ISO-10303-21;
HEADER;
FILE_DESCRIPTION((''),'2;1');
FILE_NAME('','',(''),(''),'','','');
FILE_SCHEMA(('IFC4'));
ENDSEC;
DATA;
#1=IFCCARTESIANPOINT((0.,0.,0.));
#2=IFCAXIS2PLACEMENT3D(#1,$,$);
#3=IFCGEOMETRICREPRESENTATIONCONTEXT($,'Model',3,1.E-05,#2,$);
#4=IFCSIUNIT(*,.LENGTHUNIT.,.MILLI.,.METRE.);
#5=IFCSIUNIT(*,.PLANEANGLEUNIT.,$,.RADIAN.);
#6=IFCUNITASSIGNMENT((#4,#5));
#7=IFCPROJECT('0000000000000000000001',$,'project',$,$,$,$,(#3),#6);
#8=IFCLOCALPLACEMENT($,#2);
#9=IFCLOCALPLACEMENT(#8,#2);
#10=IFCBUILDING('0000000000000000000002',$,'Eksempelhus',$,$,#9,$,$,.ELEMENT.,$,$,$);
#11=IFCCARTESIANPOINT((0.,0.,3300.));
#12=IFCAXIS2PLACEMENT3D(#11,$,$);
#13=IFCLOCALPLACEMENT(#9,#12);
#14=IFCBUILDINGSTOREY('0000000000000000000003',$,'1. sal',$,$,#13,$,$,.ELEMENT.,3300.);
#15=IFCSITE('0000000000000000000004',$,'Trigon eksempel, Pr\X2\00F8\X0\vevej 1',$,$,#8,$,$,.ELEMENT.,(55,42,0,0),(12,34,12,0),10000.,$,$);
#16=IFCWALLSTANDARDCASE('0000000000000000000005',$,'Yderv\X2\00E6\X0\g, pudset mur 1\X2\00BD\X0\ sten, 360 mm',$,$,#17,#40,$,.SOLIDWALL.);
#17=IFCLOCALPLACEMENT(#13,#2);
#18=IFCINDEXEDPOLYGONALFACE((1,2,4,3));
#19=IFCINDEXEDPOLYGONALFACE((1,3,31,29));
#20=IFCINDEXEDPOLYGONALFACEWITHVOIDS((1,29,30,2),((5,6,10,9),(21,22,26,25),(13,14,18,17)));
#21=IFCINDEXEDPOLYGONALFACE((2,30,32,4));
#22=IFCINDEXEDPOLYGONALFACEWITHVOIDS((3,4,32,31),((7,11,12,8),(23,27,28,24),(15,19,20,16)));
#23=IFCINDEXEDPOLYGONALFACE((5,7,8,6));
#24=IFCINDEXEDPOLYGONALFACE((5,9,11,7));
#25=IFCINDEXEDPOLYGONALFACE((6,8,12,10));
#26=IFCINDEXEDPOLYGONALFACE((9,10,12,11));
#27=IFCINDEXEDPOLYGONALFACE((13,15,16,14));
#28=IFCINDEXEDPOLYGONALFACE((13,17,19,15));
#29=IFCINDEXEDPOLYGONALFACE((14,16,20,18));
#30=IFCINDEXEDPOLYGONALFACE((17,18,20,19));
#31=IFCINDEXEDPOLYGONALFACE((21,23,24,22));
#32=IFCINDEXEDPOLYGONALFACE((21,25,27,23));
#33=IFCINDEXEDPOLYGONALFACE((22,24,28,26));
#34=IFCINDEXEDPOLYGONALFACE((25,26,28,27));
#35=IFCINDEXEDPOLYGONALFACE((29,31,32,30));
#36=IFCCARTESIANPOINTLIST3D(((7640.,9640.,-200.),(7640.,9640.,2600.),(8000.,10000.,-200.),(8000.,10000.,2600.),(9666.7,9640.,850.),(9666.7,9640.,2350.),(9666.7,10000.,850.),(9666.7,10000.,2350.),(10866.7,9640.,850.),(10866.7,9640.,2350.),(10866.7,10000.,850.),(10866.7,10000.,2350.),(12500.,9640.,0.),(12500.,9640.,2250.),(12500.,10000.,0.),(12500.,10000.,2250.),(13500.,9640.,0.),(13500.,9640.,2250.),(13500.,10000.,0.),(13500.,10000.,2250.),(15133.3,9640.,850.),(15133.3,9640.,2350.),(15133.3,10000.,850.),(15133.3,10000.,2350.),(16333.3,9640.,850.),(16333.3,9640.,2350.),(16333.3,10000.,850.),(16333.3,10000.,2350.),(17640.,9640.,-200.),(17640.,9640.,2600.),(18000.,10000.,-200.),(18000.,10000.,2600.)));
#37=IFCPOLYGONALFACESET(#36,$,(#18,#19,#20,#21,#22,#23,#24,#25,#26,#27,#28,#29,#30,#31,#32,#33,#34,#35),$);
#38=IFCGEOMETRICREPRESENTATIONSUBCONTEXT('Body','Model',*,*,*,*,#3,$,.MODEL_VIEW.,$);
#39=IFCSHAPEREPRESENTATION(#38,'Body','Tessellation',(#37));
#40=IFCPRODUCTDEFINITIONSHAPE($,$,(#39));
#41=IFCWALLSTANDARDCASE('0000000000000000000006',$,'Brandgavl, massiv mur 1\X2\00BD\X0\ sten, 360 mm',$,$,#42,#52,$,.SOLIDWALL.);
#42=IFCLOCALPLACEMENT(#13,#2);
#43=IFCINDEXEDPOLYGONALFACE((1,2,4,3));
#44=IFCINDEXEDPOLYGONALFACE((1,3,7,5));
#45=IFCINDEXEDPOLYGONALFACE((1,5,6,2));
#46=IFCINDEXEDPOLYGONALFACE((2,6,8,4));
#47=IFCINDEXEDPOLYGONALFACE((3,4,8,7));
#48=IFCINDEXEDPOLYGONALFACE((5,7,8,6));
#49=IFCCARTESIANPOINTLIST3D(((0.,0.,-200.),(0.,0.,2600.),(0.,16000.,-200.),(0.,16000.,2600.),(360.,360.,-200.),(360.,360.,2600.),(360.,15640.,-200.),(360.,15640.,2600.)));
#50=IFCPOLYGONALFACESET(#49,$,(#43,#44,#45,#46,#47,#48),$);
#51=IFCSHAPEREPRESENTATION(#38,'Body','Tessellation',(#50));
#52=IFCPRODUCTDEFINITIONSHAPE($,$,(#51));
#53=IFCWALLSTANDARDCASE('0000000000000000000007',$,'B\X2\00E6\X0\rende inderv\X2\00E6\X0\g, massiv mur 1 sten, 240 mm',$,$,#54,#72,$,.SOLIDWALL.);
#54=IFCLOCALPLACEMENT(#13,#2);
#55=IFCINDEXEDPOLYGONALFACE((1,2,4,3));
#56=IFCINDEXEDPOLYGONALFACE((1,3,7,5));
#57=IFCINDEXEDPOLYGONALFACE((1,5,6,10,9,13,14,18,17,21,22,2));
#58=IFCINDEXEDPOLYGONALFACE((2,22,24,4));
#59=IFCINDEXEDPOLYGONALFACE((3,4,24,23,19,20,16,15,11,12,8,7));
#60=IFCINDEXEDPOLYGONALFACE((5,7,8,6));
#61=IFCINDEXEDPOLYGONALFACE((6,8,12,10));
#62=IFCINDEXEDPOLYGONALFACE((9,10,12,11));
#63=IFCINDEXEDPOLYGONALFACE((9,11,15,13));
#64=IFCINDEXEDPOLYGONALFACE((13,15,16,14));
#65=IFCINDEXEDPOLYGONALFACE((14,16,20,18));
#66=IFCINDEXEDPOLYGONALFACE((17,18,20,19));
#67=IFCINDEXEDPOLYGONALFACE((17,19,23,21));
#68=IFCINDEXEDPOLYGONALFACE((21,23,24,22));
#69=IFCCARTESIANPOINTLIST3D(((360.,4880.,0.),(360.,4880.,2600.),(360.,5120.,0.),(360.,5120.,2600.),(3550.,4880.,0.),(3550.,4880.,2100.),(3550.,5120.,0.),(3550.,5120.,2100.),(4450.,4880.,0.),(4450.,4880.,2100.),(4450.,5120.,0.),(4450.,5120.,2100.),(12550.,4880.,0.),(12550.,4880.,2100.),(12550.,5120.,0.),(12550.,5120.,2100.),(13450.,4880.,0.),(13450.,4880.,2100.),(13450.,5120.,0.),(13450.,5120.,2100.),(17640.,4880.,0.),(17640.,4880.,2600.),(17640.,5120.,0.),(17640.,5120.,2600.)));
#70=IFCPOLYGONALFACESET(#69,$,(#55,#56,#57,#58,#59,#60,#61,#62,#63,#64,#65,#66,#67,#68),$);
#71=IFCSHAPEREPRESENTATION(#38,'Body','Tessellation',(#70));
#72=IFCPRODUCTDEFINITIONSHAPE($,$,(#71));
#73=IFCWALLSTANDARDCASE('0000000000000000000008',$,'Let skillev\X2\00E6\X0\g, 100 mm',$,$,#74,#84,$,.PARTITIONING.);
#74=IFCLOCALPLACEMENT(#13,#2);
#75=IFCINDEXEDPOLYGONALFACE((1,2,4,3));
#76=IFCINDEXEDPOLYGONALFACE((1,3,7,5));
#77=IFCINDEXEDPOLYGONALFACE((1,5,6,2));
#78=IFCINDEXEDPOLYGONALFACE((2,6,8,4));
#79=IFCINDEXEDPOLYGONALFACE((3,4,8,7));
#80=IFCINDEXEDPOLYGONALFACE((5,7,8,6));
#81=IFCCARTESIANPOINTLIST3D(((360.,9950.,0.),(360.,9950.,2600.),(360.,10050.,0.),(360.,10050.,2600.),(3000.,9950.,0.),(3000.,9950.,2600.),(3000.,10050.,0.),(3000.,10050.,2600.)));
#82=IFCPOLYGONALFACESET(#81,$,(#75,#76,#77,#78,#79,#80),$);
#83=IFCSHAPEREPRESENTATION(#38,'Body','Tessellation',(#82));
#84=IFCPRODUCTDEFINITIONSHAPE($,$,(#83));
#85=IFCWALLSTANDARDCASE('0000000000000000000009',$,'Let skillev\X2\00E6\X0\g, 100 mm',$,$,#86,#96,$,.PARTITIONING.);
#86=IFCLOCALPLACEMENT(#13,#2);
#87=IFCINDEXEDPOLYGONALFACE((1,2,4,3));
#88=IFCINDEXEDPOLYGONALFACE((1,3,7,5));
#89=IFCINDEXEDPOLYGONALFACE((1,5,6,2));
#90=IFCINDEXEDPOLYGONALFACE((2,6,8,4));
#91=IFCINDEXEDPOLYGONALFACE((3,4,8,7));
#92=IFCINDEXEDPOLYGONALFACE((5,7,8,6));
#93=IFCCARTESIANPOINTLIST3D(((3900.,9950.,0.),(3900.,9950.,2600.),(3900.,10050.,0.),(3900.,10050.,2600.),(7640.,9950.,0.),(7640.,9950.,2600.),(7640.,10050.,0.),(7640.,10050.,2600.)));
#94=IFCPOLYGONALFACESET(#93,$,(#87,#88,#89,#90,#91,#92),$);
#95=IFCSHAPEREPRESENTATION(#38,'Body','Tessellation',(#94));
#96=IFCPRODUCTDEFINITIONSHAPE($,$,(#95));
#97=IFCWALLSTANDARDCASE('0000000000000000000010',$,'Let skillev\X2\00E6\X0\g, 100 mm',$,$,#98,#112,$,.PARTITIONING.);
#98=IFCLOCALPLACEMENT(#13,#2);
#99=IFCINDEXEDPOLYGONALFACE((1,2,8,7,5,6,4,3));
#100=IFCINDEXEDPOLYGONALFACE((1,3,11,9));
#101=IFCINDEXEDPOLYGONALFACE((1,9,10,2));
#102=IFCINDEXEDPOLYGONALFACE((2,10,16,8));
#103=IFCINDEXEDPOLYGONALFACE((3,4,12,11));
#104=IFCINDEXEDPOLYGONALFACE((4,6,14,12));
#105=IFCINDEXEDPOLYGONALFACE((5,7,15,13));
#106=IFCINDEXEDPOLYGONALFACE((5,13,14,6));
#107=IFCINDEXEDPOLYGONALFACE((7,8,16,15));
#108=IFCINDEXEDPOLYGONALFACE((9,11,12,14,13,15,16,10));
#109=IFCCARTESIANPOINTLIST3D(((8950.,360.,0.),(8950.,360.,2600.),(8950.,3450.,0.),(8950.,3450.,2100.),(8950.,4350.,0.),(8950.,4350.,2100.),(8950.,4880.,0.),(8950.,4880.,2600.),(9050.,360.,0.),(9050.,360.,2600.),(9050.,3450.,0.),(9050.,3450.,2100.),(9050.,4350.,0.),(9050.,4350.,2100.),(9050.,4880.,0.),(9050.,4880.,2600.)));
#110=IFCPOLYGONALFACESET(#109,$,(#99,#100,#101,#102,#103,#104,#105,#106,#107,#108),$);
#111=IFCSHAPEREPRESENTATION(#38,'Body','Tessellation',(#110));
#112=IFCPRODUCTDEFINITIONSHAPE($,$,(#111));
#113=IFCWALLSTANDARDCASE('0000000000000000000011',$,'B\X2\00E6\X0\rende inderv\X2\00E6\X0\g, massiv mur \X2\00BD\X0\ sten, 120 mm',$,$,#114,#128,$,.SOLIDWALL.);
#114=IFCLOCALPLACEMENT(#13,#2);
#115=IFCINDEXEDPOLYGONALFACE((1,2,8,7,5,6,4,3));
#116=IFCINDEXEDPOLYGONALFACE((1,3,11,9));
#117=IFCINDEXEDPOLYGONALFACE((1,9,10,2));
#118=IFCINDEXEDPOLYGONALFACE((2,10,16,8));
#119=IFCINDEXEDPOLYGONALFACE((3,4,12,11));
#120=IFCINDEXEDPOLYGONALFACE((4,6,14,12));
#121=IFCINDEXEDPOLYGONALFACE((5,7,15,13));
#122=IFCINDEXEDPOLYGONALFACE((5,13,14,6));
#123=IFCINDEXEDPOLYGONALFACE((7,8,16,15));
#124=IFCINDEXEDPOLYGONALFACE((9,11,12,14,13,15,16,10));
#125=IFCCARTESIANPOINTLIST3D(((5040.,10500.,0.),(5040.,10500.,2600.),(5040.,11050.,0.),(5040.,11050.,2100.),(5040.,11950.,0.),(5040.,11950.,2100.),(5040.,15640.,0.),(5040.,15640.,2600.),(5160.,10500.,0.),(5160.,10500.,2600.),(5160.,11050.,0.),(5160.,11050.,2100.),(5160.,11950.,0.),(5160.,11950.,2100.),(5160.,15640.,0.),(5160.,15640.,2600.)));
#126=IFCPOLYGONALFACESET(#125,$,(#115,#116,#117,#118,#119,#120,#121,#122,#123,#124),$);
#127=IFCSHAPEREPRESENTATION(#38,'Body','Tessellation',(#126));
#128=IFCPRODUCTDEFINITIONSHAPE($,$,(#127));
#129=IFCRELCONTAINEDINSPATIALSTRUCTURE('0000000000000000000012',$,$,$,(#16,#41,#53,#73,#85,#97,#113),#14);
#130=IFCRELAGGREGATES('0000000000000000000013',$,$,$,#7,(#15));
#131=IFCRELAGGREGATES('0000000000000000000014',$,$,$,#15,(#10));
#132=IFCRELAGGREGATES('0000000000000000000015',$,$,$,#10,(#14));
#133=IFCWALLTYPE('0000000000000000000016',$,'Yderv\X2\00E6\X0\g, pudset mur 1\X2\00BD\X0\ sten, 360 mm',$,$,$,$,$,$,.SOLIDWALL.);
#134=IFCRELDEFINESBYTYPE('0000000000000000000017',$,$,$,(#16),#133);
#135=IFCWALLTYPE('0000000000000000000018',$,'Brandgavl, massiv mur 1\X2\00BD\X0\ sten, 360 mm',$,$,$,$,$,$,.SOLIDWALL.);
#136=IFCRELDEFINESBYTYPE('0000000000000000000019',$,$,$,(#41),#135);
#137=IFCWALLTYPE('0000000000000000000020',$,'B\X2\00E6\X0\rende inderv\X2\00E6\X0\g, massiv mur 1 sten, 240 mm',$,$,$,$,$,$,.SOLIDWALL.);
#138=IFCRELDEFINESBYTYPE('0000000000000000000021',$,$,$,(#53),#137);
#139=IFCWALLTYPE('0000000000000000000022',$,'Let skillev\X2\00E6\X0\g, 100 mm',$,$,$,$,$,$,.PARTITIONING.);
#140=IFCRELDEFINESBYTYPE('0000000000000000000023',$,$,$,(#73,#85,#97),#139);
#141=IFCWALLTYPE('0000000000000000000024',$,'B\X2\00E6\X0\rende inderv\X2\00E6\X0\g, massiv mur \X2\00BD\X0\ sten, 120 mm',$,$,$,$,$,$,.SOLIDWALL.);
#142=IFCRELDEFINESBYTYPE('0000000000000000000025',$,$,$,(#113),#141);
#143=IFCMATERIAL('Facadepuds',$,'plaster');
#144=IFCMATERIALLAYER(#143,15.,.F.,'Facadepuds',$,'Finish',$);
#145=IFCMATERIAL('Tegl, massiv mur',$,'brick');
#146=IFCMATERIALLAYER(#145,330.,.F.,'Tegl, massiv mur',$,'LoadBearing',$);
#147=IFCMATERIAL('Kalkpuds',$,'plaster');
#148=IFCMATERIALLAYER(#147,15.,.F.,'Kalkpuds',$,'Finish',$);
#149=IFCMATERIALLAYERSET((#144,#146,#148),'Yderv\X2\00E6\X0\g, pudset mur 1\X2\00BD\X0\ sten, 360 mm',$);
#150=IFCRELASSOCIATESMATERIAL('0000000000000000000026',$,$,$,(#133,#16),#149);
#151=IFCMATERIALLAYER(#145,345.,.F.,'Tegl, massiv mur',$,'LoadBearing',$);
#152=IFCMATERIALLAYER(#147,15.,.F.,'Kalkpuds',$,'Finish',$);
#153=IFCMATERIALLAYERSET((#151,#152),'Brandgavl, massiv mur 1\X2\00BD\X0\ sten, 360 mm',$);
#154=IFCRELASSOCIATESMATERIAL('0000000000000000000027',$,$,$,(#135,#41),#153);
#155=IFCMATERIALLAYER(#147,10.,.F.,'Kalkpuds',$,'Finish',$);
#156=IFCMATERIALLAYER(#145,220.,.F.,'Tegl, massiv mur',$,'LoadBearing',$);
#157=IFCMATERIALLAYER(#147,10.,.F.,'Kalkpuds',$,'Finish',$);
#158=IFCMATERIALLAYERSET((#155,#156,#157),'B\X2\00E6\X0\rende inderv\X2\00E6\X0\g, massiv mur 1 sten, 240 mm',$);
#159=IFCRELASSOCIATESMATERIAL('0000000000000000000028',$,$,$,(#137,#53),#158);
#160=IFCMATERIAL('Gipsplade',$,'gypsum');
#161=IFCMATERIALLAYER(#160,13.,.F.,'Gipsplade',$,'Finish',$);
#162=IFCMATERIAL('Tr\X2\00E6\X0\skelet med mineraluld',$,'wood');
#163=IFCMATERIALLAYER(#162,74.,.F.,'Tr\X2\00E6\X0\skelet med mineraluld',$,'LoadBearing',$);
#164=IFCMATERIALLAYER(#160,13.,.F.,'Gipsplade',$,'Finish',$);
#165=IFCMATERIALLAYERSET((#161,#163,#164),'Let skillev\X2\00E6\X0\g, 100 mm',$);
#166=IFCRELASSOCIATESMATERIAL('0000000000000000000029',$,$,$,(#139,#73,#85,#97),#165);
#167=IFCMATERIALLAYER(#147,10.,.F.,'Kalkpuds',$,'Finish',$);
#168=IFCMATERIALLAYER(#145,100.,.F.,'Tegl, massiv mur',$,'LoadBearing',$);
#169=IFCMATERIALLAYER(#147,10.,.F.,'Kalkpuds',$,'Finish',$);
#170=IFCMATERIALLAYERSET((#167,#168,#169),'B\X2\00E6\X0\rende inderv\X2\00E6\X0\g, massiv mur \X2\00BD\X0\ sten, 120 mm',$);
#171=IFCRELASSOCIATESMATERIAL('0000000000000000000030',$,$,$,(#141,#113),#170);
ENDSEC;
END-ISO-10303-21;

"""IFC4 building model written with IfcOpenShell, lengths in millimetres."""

from ifc_helpers import new_model, si_unit, frame, origin, place, context, subcontext, project, spatial, polyline, rectangle, outline, extrude, material, layer, layer_set, layer_usage, type_object, element, save


model = new_model("IFC4")

# Units and contexts
model_context = context("Model", 3, precision=1e-05, world=origin())
body_context = subcontext(model_context, "Body", "Model", "MODEL_VIEW")
ifc_project = project(units=[si_unit("LENGTHUNIT", "METRE", prefix="MILLI"), si_unit("PLANEANGLEUNIT", "RADIAN")], contexts=[model_context])

# Site, building, storey
site_placement = place(None, origin())
site = spatial("IfcSite", under=ifc_project, at=site_placement, Name="Trigon eksempel, Prøvevej 1", CompositionType="ELEMENT", RefLatitude=(55, 42, 0, 0), RefLongitude=(12, 34, 12, 0), RefElevation=10000.0)
building_placement = place(site_placement, origin())
building = spatial("IfcBuilding", under=site, at=building_placement, Name="Eksempelhus", CompositionType="ELEMENT")
storey_placement = place(building_placement, frame((0.0, 0.0, 3300.0)))
storey = spatial("IfcBuildingStorey", under=building, at=storey_placement, Name="1. sal", CompositionType="ELEMENT", Elevation=3300.0)

# Wall, openings
ifc_material_1 = material(Name="Tegl, massiv mur", Category="brick")
ifc_material_2 = material(Name="Kalkpuds", Category="plaster")
ifc_material_3 = material(Name="Facadepuds", Category="plaster")
ifc_layer_1 = layer(ifc_material_3, 15.0, ventilated=False, Name="Facadepuds", Category="Finish")
ifc_layer_2 = layer(ifc_material_1, 330.0, ventilated=False, Name="Tegl, massiv mur", Category="LoadBearing")
ifc_layer_3 = layer(ifc_material_2, 15.0, ventilated=False, Name="Kalkpuds", Category="Finish")
ifc_layer_set_1 = layer_set([ifc_layer_1, ifc_layer_2, ifc_layer_3], Name="Ydervæg, pudset mur 1½ sten, 360 mm")
ifc_layer_usage_1 = layer_usage(ifc_layer_set_1, "AXIS2", "POSITIVE", 0.0)
wall_type_1 = type_object("IfcWallType", Name="Ydervæg, pudset mur 1½ sten, 360 mm", PredefinedType="SOLIDWALL", material=ifc_layer_set_1)
wall_1_placement = place(storey_placement, frame((18000.0, 10000.0, -200.0), z_axis=(0.0, 0.0, 1.0), x_axis=(-1.0, 0.0, 0.0)))
wall_1 = element("IfcWallStandardCase", 1, at=wall_1_placement, inside=storey, type_object=wall_type_1, material=ifc_layer_usage_1, Name="Ydervæg, pudset mur 1½ sten, 360 mm", PredefinedType="SOLIDWALL", context=body_context, shape_type="SweptSolid", body=[
    extrude(outline(polyline([(0.0, 0.0), (10000.0, 0.0), (10360.0, 360.0), (360.0, 360.0), (0.0, 0.0)])), origin(), (0.0, 0.0, 1.0), 2800.0),
])
opening_1_placement = place(wall_1_placement, frame((1666.7, 0.0, 1050.0)))
element("IfcOpeningElement", 2, at=opening_1_placement, cuts=wall_1, PredefinedType="OPENING", context=body_context, shape_type="SweptSolid", body=[
    extrude(rectangle(XDim=1200.0, YDim=1500.0), frame((600.0, 0.0, 750.0), z_axis=(0.0, 1.0, 0.0), x_axis=(1.0, 0.0, 0.0)), (0.0, 0.0, 1.0), 360.0),
])
opening_2_placement = place(wall_1_placement, frame((4500.0, 0.0, 200.0)))
element("IfcOpeningElement", 3, at=opening_2_placement, cuts=wall_1, PredefinedType="OPENING", context=body_context, shape_type="SweptSolid", body=[
    extrude(rectangle(XDim=1000.0, YDim=2250.0), frame((500.0, 0.0, 1125.0), z_axis=(0.0, 1.0, 0.0), x_axis=(1.0, 0.0, 0.0)), (0.0, 0.0, 1.0), 360.0),
])
opening_3_placement = place(wall_1_placement, frame((7133.3, 0.0, 1050.0)))
element("IfcOpeningElement", 4, at=opening_3_placement, cuts=wall_1, PredefinedType="OPENING", context=body_context, shape_type="SweptSolid", body=[
    extrude(rectangle(XDim=1200.0, YDim=1500.0), frame((600.0, 0.0, 750.0), z_axis=(0.0, 1.0, 0.0), x_axis=(1.0, 0.0, 0.0)), (0.0, 0.0, 1.0), 360.0),
])

# Wall
ifc_layer_4 = layer(ifc_material_1, 345.0, ventilated=False, Name="Tegl, massiv mur", Category="LoadBearing")
ifc_layer_5 = layer(ifc_material_2, 15.0, ventilated=False, Name="Kalkpuds", Category="Finish")
ifc_layer_set_2 = layer_set([ifc_layer_4, ifc_layer_5], Name="Brandgavl, massiv mur 1½ sten, 360 mm")
ifc_layer_usage_2 = layer_usage(ifc_layer_set_2, "AXIS2", "POSITIVE", 0.0)
wall_type_2 = type_object("IfcWallType", Name="Brandgavl, massiv mur 1½ sten, 360 mm", PredefinedType="SOLIDWALL", material=ifc_layer_set_2)
wall_2_placement = place(storey_placement, frame((0.0, 16000.0, -200.0), z_axis=(0.0, 0.0, 1.0), x_axis=(0.0, -1.0, 0.0)))
element("IfcWallStandardCase", 5, at=wall_2_placement, inside=storey, type_object=wall_type_2, material=ifc_layer_usage_2, Name="Brandgavl, massiv mur 1½ sten, 360 mm", PredefinedType="SOLIDWALL", context=body_context, shape_type="SweptSolid", body=[
    extrude(outline(polyline([(0.0, 0.0), (16000.0, 0.0), (15640.0, 360.0), (360.0, 360.0), (0.0, 0.0)])), origin(), (0.0, 0.0, 1.0), 2800.0),
])

# Wall, openings
ifc_layer_6 = layer(ifc_material_2, 10.0, ventilated=False, Name="Kalkpuds", Category="Finish")
ifc_layer_7 = layer(ifc_material_1, 220.0, ventilated=False, Name="Tegl, massiv mur", Category="LoadBearing")
ifc_layer_8 = layer(ifc_material_2, 10.0, ventilated=False, Name="Kalkpuds", Category="Finish")
ifc_layer_set_3 = layer_set([ifc_layer_6, ifc_layer_7, ifc_layer_8], Name="Bærende indervæg, massiv mur 1 sten, 240 mm")
ifc_layer_usage_3 = layer_usage(ifc_layer_set_3, "AXIS2", "POSITIVE", -120.0)
wall_type_3 = type_object("IfcWallType", Name="Bærende indervæg, massiv mur 1 sten, 240 mm", PredefinedType="SOLIDWALL", material=ifc_layer_set_3)
wall_3_placement = place(storey_placement, frame((360.0, 5000.0, 0.0)))
wall_3 = element("IfcWallStandardCase", 6, at=wall_3_placement, inside=storey, type_object=wall_type_3, material=ifc_layer_usage_3, Name="Bærende indervæg, massiv mur 1 sten, 240 mm", PredefinedType="SOLIDWALL", context=body_context, shape_type="SweptSolid", body=[
    extrude(outline(polyline([(0.0, -120.0), (17280.0, -120.0), (17280.0, 120.0), (0.0, 120.0), (0.0, -120.0)])), origin(), (0.0, 0.0, 1.0), 2600.0),
])
opening_4_placement = place(wall_3_placement, frame((3190.0, -120.0, 0.0)))
element("IfcOpeningElement", 7, at=opening_4_placement, cuts=wall_3, PredefinedType="OPENING", context=body_context, shape_type="SweptSolid", body=[
    extrude(rectangle(XDim=900.0, YDim=2100.0), frame((450.0, 0.0, 1050.0), z_axis=(0.0, 1.0, 0.0), x_axis=(1.0, 0.0, 0.0)), (0.0, 0.0, 1.0), 240.0),
])
opening_5_placement = place(wall_3_placement, frame((12190.0, -120.0, 0.0)))
element("IfcOpeningElement", 8, at=opening_5_placement, cuts=wall_3, PredefinedType="OPENING", context=body_context, shape_type="SweptSolid", body=[
    extrude(rectangle(XDim=900.0, YDim=2100.0), frame((450.0, 0.0, 1050.0), z_axis=(0.0, 1.0, 0.0), x_axis=(1.0, 0.0, 0.0)), (0.0, 0.0, 1.0), 240.0),
])

# Walls
ifc_material_4 = material(Name="Gipsplade", Category="gypsum")
ifc_layer_9 = layer(ifc_material_4, 13.0, ventilated=False, Name="Gipsplade", Category="Finish")
ifc_material_5 = material(Name="Træskelet med mineraluld", Category="wood")
ifc_layer_10 = layer(ifc_material_5, 74.0, ventilated=False, Name="Træskelet med mineraluld", Category="LoadBearing")
ifc_layer_11 = layer(ifc_material_4, 13.0, ventilated=False, Name="Gipsplade", Category="Finish")
ifc_layer_set_4 = layer_set([ifc_layer_9, ifc_layer_10, ifc_layer_11], Name="Let skillevæg, 100 mm")
ifc_layer_usage_4 = layer_usage(ifc_layer_set_4, "AXIS2", "POSITIVE", -50.0)
wall_type_4 = type_object("IfcWallType", Name="Let skillevæg, 100 mm", PredefinedType="PARTITIONING", material=ifc_layer_set_4)
wall_4_placement = place(storey_placement, frame((360.0, 10000.0, 0.0)))
element("IfcWallStandardCase", 9, at=wall_4_placement, inside=storey, type_object=wall_type_4, material=ifc_layer_usage_4, Name="Let skillevæg, 100 mm", PredefinedType="PARTITIONING", context=body_context, shape_type="SweptSolid", body=[
    extrude(outline(polyline([(0.0, -50.0), (2640.0, -50.0), (2640.0, 50.0), (0.0, 50.0), (0.0, -50.0)])), origin(), (0.0, 0.0, 1.0), 2600.0),
])
wall_5_placement = place(storey_placement, frame((3900.0, 10000.0, 0.0)))
element("IfcWallStandardCase", 10, at=wall_5_placement, inside=storey, type_object=wall_type_4, material=ifc_layer_usage_4, Name="Let skillevæg, 100 mm", PredefinedType="PARTITIONING", context=body_context, shape_type="SweptSolid", body=[
    extrude(outline(polyline([(0.0, -50.0), (3740.0, -50.0), (3740.0, 50.0), (0.0, 50.0), (0.0, -50.0)])), origin(), (0.0, 0.0, 1.0), 2600.0),
])

# Walls, openings
wall_6_placement = place(storey_placement, frame((9000.0, 360.0, 0.0), z_axis=(0.0, 0.0, 1.0), x_axis=(0.0, 1.0, 0.0)))
wall_6 = element("IfcWallStandardCase", 11, at=wall_6_placement, inside=storey, type_object=wall_type_4, material=ifc_layer_usage_4, Name="Let skillevæg, 100 mm", PredefinedType="PARTITIONING", context=body_context, shape_type="SweptSolid", body=[
    extrude(outline(polyline([(0.0, -50.0), (4520.0, -50.0), (4520.0, 50.0), (0.0, 50.0), (0.0, -50.0)])), origin(), (0.0, 0.0, 1.0), 2600.0),
])
opening_6_placement = place(wall_6_placement, frame((3090.0, -50.0, 0.0)))
element("IfcOpeningElement", 12, at=opening_6_placement, cuts=wall_6, PredefinedType="OPENING", context=body_context, shape_type="SweptSolid", body=[
    extrude(rectangle(XDim=900.0, YDim=2100.0), frame((450.0, 0.0, 1050.0), z_axis=(0.0, 1.0, 0.0), x_axis=(1.0, 0.0, 0.0)), (0.0, 0.0, 1.0), 100.0),
])
ifc_layer_12 = layer(ifc_material_2, 10.0, ventilated=False, Name="Kalkpuds", Category="Finish")
ifc_layer_13 = layer(ifc_material_1, 100.0, ventilated=False, Name="Tegl, massiv mur", Category="LoadBearing")
ifc_layer_14 = layer(ifc_material_2, 10.0, ventilated=False, Name="Kalkpuds", Category="Finish")
ifc_layer_set_5 = layer_set([ifc_layer_12, ifc_layer_13, ifc_layer_14], Name="Bærende indervæg, massiv mur ½ sten, 120 mm")
ifc_layer_usage_5 = layer_usage(ifc_layer_set_5, "AXIS2", "POSITIVE", -60.0)
wall_type_5 = type_object("IfcWallType", Name="Bærende indervæg, massiv mur ½ sten, 120 mm", PredefinedType="SOLIDWALL", material=ifc_layer_set_5)
wall_7_placement = place(storey_placement, frame((5100.0, 10500.0, 0.0), z_axis=(0.0, 0.0, 1.0), x_axis=(0.0, 1.0, 0.0)))
wall_7 = element("IfcWallStandardCase", 13, at=wall_7_placement, inside=storey, type_object=wall_type_5, material=ifc_layer_usage_5, Name="Bærende indervæg, massiv mur ½ sten, 120 mm", PredefinedType="SOLIDWALL", context=body_context, shape_type="SweptSolid", body=[
    extrude(outline(polyline([(0.0, -60.0), (5140.0, -60.0), (5140.0, 60.0), (0.0, 60.0), (0.0, -60.0)])), origin(), (0.0, 0.0, 1.0), 2600.0),
])
opening_7_placement = place(wall_7_placement, frame((550.0, -60.0, 0.0)))
element("IfcOpeningElement", 14, at=opening_7_placement, cuts=wall_7, PredefinedType="OPENING", context=body_context, shape_type="SweptSolid", body=[
    extrude(rectangle(XDim=900.0, YDim=2100.0), frame((450.0, 0.0, 1050.0), z_axis=(0.0, 1.0, 0.0), x_axis=(1.0, 0.0, 0.0)), (0.0, 0.0, 1.0), 120.0),
])

save(model, "model.ifc")
